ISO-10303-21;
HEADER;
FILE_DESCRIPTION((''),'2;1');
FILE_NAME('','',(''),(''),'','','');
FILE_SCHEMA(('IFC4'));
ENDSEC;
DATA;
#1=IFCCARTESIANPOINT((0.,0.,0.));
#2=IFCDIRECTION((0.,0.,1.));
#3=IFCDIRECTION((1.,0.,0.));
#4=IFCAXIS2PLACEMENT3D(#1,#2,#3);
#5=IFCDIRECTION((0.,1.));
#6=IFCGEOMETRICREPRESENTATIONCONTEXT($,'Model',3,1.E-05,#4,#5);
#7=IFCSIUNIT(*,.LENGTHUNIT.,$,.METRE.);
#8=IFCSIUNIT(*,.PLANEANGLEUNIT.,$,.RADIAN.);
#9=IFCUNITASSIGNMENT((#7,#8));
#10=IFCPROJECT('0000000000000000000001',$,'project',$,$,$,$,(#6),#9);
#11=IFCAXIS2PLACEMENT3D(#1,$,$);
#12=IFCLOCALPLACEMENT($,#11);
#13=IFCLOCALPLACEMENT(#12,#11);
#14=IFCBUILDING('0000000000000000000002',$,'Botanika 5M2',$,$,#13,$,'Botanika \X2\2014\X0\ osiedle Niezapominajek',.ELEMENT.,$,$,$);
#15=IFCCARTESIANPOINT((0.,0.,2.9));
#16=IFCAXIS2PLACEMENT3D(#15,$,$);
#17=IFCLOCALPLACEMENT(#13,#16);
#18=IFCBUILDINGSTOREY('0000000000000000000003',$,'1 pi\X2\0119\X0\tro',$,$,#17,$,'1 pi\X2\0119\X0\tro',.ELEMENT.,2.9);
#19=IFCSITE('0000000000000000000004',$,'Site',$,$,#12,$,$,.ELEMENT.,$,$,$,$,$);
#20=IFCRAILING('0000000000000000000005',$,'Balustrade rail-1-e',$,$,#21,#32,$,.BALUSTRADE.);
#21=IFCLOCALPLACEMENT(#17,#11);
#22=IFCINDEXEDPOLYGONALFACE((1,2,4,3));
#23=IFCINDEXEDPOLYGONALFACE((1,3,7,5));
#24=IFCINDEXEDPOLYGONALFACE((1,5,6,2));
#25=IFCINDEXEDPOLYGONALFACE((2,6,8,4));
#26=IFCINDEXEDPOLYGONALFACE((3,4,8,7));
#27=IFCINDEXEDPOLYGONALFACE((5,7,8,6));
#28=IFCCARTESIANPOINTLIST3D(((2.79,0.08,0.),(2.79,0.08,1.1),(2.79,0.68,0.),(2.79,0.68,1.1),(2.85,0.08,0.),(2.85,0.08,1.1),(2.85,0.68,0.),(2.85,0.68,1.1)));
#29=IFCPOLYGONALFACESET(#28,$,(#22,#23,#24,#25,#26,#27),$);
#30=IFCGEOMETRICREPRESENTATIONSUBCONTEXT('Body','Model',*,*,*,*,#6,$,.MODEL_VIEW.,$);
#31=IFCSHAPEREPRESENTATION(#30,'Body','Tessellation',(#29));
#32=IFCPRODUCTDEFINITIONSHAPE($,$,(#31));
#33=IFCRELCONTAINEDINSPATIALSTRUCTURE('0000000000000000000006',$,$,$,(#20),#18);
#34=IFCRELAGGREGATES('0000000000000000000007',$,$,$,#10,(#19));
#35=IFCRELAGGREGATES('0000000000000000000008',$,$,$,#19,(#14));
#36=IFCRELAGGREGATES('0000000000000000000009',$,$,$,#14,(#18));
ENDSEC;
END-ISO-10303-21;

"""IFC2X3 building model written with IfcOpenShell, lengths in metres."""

from ifc_helpers import new_model, si_unit, direction, frame, frame_2d, origin, origin_with_axes, place, context, subcontext, project, spatial, rectangle, extrude, element, save


model = new_model("IFC2X3")

# Units and contexts
model_context = context("Model", 3, precision=1e-05, world=origin_with_axes(), true_north=direction((0.0, 1.0)))
body_context = subcontext(model_context, "Body", "Model", "MODEL_VIEW")
ifc_project = project(units=[si_unit("LENGTHUNIT", "METRE"), si_unit("PLANEANGLEUNIT", "RADIAN")], contexts=[model_context])

# Site, building, storey
site_placement = place(None, origin())
site = spatial("IfcSite", under=ifc_project, at=site_placement, Name="Site", CompositionType="ELEMENT")
building_placement = place(site_placement, origin())
building = spatial("IfcBuilding", under=site, at=building_placement, Name="Botanika 5M2", LongName="Botanika — osiedle Niezapominajek", CompositionType="ELEMENT")
storey_placement = place(building_placement, frame((0.0, 0.0, 2.9)))
storey = spatial("IfcBuildingStorey", under=building, at=storey_placement, Name="1 piętro", LongName="1 piętro", CompositionType="ELEMENT", Elevation=2.9)

# Railing
railing_1_placement = place(storey_placement, frame((2.79, 0.08, 0.0)))
element("IfcRailing", 1, at=railing_1_placement, inside=storey, Name="Balustrade rail-1-e", PredefinedType="BALUSTRADE", context=body_context, shape_type="SweptSolid", body=[
    extrude(rectangle(XDim=0.06, YDim=0.6, at=frame_2d((0.03, 0.3))), origin_with_axes(), (0.0, 0.0, 1.0), 1.1),
])

save(model, "model.ifc")
